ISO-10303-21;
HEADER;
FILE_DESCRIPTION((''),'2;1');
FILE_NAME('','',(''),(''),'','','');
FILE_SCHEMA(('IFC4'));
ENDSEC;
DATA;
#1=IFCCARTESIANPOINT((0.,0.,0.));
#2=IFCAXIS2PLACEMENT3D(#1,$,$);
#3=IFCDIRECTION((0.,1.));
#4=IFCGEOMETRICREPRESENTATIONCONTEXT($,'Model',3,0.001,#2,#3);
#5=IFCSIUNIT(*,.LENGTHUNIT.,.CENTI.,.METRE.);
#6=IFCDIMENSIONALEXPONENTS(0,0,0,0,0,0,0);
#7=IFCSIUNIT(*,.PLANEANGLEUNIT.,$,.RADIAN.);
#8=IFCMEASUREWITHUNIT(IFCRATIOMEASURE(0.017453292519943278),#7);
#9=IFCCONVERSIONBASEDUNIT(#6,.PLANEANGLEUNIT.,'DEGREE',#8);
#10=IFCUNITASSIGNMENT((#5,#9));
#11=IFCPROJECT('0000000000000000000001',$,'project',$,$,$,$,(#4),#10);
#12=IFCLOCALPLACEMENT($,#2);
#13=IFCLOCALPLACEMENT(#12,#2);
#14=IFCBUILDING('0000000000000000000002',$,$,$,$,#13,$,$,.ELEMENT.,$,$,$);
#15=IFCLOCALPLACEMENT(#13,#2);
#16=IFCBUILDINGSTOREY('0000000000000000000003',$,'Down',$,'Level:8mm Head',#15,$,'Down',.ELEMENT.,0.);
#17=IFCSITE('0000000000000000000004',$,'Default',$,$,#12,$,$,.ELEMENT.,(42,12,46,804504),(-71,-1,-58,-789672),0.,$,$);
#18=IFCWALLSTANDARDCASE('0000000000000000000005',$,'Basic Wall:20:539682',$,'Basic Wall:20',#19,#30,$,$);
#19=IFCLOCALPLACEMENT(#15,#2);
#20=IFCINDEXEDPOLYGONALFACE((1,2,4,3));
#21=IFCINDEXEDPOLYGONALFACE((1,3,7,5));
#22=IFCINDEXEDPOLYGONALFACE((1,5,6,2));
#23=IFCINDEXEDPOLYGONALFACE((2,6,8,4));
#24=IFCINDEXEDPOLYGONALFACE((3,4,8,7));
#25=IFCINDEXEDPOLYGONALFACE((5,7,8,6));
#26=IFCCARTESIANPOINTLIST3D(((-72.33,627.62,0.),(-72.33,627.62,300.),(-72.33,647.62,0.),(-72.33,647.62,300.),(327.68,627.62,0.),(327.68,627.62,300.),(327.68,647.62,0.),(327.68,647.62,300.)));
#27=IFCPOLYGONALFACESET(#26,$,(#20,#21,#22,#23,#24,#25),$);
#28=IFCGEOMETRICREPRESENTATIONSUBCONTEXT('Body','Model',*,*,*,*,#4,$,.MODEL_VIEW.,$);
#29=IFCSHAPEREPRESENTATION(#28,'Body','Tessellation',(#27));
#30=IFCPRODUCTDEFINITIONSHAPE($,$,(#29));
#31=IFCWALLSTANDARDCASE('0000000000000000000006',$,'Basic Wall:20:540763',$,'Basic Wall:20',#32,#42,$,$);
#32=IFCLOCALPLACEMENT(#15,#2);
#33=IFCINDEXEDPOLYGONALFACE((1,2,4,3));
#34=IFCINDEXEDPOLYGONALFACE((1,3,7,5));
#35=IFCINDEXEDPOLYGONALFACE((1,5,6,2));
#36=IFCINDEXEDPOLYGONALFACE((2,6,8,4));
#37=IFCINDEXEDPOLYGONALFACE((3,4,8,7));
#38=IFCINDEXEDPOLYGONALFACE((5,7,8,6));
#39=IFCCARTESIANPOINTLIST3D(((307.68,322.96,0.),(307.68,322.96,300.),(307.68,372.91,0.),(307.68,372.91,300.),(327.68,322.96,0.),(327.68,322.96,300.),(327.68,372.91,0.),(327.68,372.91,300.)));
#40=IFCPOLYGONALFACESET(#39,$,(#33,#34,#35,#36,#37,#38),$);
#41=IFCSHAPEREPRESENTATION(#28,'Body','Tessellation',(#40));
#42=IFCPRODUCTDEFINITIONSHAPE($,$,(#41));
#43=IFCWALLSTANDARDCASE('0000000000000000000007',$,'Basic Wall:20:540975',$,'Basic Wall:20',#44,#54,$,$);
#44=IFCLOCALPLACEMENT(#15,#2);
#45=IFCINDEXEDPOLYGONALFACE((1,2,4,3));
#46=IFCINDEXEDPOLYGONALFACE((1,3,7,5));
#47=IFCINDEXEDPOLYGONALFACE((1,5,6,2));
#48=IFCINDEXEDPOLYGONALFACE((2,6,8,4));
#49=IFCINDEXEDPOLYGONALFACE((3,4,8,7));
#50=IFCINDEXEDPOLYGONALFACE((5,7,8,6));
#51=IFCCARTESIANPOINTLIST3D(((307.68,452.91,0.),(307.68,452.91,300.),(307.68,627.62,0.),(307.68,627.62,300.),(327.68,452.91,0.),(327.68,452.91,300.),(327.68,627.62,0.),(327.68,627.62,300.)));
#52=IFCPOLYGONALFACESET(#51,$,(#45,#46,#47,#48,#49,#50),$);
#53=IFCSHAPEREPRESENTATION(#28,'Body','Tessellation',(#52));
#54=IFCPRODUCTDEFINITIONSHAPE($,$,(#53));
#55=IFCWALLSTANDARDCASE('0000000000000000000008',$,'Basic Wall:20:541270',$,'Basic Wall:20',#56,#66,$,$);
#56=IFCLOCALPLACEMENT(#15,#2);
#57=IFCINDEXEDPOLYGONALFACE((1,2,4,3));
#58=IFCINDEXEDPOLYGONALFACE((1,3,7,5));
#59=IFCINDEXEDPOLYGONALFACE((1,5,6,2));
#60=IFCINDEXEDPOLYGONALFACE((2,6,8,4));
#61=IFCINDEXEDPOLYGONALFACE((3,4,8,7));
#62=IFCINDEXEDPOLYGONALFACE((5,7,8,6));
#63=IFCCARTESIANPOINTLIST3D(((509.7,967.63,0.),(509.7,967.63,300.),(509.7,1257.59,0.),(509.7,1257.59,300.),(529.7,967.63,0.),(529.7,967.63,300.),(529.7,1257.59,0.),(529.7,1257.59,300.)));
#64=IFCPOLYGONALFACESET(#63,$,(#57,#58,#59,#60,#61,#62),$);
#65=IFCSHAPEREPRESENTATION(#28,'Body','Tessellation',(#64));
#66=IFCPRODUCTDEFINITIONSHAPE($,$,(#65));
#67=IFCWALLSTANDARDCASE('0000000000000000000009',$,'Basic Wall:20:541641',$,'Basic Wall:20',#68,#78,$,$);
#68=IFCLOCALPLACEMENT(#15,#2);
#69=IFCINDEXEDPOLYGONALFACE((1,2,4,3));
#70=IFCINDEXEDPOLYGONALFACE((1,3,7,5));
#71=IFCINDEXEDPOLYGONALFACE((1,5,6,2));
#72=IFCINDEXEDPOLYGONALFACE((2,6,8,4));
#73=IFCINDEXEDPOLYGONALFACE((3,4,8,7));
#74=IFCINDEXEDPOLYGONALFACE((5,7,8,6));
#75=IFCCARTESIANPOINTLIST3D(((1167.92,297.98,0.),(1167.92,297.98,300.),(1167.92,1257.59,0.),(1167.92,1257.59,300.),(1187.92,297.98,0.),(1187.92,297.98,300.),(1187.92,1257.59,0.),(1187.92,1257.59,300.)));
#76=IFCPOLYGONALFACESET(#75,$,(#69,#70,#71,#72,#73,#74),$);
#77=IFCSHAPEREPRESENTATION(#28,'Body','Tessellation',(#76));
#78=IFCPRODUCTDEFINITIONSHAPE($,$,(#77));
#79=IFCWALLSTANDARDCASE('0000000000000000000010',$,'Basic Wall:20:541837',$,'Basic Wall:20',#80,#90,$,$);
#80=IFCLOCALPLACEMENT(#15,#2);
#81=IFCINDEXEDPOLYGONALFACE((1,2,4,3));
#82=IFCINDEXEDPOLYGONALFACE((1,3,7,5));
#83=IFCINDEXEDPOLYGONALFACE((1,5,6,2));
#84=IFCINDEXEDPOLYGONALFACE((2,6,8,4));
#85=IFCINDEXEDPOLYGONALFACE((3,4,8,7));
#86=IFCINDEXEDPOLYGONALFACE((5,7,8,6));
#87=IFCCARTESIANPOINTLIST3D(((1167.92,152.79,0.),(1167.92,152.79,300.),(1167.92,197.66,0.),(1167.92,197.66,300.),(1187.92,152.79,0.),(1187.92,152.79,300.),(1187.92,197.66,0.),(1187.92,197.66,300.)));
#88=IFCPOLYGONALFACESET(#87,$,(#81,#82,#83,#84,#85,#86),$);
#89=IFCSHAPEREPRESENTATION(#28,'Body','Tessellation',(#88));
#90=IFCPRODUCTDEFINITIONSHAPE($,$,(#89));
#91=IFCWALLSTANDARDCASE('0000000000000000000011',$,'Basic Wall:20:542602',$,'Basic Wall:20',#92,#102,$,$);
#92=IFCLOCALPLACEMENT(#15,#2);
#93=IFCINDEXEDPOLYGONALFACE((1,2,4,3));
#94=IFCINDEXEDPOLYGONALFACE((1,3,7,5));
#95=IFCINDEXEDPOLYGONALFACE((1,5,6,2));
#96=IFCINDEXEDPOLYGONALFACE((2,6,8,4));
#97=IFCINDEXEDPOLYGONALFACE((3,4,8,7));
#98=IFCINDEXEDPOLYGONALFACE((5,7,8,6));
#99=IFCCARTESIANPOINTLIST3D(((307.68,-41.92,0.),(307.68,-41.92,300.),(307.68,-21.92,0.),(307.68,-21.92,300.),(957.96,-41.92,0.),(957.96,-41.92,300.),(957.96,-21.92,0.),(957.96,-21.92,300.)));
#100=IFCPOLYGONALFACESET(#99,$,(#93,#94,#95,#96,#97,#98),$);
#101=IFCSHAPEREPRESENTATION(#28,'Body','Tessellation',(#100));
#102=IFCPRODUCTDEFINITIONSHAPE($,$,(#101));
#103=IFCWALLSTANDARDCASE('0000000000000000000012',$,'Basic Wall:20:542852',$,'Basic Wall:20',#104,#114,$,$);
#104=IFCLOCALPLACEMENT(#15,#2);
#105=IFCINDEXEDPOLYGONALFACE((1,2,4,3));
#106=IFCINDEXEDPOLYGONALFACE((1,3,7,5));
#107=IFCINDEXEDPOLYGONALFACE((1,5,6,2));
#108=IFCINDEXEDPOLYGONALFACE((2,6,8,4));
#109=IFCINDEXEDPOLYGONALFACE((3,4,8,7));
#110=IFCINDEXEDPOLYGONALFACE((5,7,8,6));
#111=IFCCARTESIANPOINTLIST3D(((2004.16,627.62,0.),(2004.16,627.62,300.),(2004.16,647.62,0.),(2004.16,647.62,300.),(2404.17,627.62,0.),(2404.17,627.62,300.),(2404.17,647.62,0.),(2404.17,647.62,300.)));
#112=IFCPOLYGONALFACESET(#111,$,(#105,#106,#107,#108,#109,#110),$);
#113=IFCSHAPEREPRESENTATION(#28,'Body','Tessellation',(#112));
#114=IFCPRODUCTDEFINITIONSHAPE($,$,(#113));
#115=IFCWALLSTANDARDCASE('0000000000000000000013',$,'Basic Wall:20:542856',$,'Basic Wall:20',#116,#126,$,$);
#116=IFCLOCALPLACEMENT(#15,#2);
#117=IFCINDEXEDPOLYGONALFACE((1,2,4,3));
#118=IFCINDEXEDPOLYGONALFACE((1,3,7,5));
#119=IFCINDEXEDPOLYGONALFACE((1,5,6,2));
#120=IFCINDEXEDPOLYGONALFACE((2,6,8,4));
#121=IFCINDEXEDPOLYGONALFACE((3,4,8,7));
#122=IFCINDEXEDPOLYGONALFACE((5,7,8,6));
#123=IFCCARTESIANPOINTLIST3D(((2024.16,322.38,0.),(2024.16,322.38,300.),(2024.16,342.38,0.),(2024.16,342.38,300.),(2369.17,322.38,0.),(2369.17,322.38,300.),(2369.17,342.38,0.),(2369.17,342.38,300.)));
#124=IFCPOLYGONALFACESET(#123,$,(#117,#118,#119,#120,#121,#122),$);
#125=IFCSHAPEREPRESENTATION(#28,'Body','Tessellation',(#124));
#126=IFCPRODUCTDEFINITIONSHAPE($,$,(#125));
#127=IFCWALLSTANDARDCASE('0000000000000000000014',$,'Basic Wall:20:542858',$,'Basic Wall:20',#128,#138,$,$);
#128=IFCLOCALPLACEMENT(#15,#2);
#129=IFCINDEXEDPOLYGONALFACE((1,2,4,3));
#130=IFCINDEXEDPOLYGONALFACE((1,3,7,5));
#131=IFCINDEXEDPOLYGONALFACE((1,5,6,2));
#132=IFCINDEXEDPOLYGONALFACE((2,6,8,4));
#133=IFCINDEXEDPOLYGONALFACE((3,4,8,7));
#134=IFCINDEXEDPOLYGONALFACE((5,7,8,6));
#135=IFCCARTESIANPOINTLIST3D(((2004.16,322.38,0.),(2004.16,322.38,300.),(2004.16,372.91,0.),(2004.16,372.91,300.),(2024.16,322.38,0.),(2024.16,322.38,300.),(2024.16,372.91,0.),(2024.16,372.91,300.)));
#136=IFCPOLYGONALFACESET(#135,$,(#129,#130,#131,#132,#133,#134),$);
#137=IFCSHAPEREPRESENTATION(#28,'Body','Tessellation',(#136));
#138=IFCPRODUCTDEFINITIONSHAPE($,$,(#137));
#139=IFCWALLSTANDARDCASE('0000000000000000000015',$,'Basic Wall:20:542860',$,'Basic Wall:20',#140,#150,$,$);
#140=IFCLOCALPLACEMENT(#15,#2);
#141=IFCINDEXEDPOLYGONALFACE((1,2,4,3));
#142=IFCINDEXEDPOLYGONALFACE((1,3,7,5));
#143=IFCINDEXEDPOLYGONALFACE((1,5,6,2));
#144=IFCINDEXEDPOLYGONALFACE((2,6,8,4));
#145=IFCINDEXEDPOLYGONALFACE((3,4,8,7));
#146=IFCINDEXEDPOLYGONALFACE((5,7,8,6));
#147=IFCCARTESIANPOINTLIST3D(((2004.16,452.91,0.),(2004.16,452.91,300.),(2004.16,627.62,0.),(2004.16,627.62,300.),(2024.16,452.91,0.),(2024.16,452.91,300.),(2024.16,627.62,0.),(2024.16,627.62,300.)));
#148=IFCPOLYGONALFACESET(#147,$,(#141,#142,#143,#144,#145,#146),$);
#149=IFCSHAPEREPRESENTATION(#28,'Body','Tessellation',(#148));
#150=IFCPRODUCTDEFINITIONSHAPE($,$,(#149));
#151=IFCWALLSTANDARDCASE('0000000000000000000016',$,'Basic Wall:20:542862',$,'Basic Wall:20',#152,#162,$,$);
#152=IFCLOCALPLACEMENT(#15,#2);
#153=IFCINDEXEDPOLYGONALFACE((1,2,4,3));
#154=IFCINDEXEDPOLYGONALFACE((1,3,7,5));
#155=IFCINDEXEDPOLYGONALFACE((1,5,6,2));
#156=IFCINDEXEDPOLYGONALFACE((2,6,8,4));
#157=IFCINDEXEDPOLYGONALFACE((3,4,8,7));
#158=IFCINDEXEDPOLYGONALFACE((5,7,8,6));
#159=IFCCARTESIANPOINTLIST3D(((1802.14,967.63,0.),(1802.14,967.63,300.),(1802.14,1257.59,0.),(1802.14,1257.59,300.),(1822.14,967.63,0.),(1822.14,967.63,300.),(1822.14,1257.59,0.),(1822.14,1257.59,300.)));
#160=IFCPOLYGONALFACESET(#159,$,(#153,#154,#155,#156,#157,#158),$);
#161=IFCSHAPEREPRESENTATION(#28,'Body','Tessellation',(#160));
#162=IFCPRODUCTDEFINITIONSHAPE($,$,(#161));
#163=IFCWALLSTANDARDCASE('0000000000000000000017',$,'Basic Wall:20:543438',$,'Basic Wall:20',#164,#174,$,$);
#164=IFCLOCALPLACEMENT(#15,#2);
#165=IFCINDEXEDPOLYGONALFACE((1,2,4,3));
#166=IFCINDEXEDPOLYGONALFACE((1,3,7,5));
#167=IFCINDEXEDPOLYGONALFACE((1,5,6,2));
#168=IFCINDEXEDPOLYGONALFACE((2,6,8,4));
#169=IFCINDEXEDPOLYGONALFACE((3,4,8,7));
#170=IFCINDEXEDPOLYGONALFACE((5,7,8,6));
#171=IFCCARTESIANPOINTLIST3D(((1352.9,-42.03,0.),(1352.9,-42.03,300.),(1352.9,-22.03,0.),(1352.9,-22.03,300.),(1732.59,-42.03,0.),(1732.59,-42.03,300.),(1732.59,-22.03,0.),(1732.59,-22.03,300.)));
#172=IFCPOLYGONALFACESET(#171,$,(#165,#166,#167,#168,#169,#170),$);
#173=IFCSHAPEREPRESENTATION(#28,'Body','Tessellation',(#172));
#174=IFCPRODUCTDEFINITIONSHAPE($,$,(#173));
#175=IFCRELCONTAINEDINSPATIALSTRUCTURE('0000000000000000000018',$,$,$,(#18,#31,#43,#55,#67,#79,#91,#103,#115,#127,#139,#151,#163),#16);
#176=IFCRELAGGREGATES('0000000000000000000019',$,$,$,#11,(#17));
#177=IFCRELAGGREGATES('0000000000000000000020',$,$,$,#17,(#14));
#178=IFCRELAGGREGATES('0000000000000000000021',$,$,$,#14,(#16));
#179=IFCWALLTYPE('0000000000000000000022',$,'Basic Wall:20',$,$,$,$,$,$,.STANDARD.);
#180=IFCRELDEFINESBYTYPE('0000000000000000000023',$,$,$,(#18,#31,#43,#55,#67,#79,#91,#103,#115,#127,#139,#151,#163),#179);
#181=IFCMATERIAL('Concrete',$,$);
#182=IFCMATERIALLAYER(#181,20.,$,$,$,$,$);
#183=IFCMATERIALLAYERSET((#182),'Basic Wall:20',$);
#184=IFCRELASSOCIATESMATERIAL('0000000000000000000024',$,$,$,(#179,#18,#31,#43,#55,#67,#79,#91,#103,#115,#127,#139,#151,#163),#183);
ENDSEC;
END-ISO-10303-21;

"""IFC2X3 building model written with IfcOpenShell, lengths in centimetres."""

from ifc_helpers import new_model, entity, si_unit, converted_unit, direction, frame, frame_2d, origin, place, context, subcontext, project, spatial, rectangle, extrude, material, layer, layer_set, layer_usage, type_object, element, save


model = new_model("IFC2X3")

# Units and contexts
model_context = context("Model", 3, precision=0.001, world=origin(), true_north=direction((0.0, 1.0)))
body_context = subcontext(model_context, "Body", "Model", "MODEL_VIEW")
ifc_project = project(units=[si_unit("LENGTHUNIT", "METRE", prefix="CENTI"), converted_unit("PLANEANGLEUNIT", "DEGREE", entity("IfcRatioMeasure", 0.017453292519943278), si_unit("PLANEANGLEUNIT", "RADIAN"), dimensions=[0, 0, 0, 0, 0, 0, 0])], contexts=[model_context])

# Site, building, storey
site_placement = place(None, origin())
site = spatial("IfcSite", under=ifc_project, at=site_placement, Name="Default", CompositionType="ELEMENT", RefLatitude=(42, 12, 46, 804504), RefLongitude=(-71, -1, -58, -789672), RefElevation=0.0)
building_placement = place(site_placement, origin())
building = spatial("IfcBuilding", under=site, at=building_placement, CompositionType="ELEMENT")
storey_placement = place(building_placement, origin())
storey = spatial("IfcBuildingStorey", under=building, at=storey_placement, Name="Down", ObjectType="Level:8mm Head", LongName="Down", CompositionType="ELEMENT", Elevation=0.0)

# Shared definitions
ifc_material = material(Name="Concrete")

# Walls
ifc_layer_1 = layer(ifc_material, 20.0)
ifc_layer_set_1 = layer_set([ifc_layer_1], Name="Basic Wall:20")
ifc_layer_usage_1 = layer_usage(ifc_layer_set_1, "AXIS2", "POSITIVE", -10.0)
wall_type_1 = type_object("IfcWallType", Name="Basic Wall:20", PredefinedType="STANDARD", material=ifc_layer_set_1)
wall_1_placement = place(storey_placement, frame((327.68, 637.62, 0.0), z_axis=(0.0, 0.0, 1.0), x_axis=(-1.0, 0.0, 0.0)))
element("IfcWallStandardCase", 1, at=wall_1_placement, inside=storey, type_object=wall_type_1, material=ifc_layer_usage_1, Name="Basic Wall:20:539682", ObjectType="Basic Wall:20", context=body_context, shape_type="SweptSolid", body=[
    extrude(rectangle(XDim=400.01, YDim=20.0, at=frame_2d((200.01, 0.0), x_axis=(-1.0, 0.0))), origin(), (0.0, 0.0, 1.0), 300.0),
])
ifc_layer_usage_2 = layer_usage(ifc_layer_set_1, "AXIS2", "POSITIVE", -10.0)
wall_2_placement = place(storey_placement, frame((317.68, 322.96, 0.0), z_axis=(0.0, 0.0, 1.0), x_axis=(0.0, 1.0, 0.0)))
element("IfcWallStandardCase", 2, at=wall_2_placement, inside=storey, type_object=wall_type_1, material=ifc_layer_usage_2, Name="Basic Wall:20:540763", ObjectType="Basic Wall:20", context=body_context, shape_type="SweptSolid", body=[
    extrude(rectangle(XDim=49.95, YDim=20.0, at=frame_2d((24.97, 0.0), x_axis=(-1.0, 0.0))), origin(), (0.0, 0.0, 1.0), 300.0),
])
ifc_layer_usage_3 = layer_usage(ifc_layer_set_1, "AXIS2", "POSITIVE", -10.0)
wall_3_placement = place(storey_placement, frame((317.68, 452.91, 0.0), z_axis=(0.0, 0.0, 1.0), x_axis=(0.0, 1.0, 0.0)))
element("IfcWallStandardCase", 3, at=wall_3_placement, inside=storey, type_object=wall_type_1, material=ifc_layer_usage_3, Name="Basic Wall:20:540975", ObjectType="Basic Wall:20", context=body_context, shape_type="SweptSolid", body=[
    extrude(rectangle(XDim=174.72, YDim=20.0, at=frame_2d((87.36, 0.0), x_axis=(-1.0, 0.0))), origin(), (0.0, 0.0, 1.0), 300.0),
])
ifc_layer_usage_4 = layer_usage(ifc_layer_set_1, "AXIS2", "NEGATIVE", 10.0)
wall_4_placement = place(storey_placement, frame((519.7, 967.63, 0.0), z_axis=(0.0, 0.0, 1.0), x_axis=(0.0, 1.0, 0.0)))
element("IfcWallStandardCase", 4, at=wall_4_placement, inside=storey, type_object=wall_type_1, material=ifc_layer_usage_4, Name="Basic Wall:20:541270", ObjectType="Basic Wall:20", context=body_context, shape_type="SweptSolid", body=[
    extrude(rectangle(XDim=289.96, YDim=20.0, at=frame_2d((144.98, 0.0), x_axis=(-1.0, 0.0))), origin(), (0.0, 0.0, 1.0), 300.0),
])
ifc_layer_usage_5 = layer_usage(ifc_layer_set_1, "AXIS2", "POSITIVE", -10.0)
wall_5_placement = place(storey_placement, frame((1177.92, 1257.59, 0.0), z_axis=(0.0, 0.0, 1.0), x_axis=(0.0, -1.0, 0.0)))
element("IfcWallStandardCase", 5, at=wall_5_placement, inside=storey, type_object=wall_type_1, material=ifc_layer_usage_5, Name="Basic Wall:20:541641", ObjectType="Basic Wall:20", context=body_context, shape_type="SweptSolid", body=[
    extrude(rectangle(XDim=959.61, YDim=20.0, at=frame_2d((479.8, 0.0), x_axis=(-1.0, 0.0))), origin(), (0.0, 0.0, 1.0), 300.0),
])
ifc_layer_usage_6 = layer_usage(ifc_layer_set_1, "AXIS2", "POSITIVE", -10.0)
wall_6_placement = place(storey_placement, frame((1177.92, 197.66, 0.0), z_axis=(0.0, 0.0, 1.0), x_axis=(0.0, -1.0, 0.0)))
element("IfcWallStandardCase", 6, at=wall_6_placement, inside=storey, type_object=wall_type_1, material=ifc_layer_usage_6, Name="Basic Wall:20:541837", ObjectType="Basic Wall:20", context=body_context, shape_type="SweptSolid", body=[
    extrude(rectangle(XDim=44.87, YDim=20.0, at=frame_2d((22.43, 0.0), x_axis=(-1.0, 0.0))), origin(), (0.0, 0.0, 1.0), 300.0),
])
ifc_layer_usage_7 = layer_usage(ifc_layer_set_1, "AXIS2", "NEGATIVE", 10.0)
wall_7_placement = place(storey_placement, frame((957.96, -31.92, 0.0), z_axis=(0.0, 0.0, 1.0), x_axis=(-1.0, 0.0, 0.0)))
element("IfcWallStandardCase", 7, at=wall_7_placement, inside=storey, type_object=wall_type_1, material=ifc_layer_usage_7, Name="Basic Wall:20:542602", ObjectType="Basic Wall:20", context=body_context, shape_type="SweptSolid", body=[
    extrude(rectangle(XDim=650.28, YDim=20.0, at=frame_2d((325.14, 0.0), x_axis=(-1.0, 0.0))), origin(), (0.0, 0.0, 1.0), 300.0),
])
ifc_layer_usage_8 = layer_usage(ifc_layer_set_1, "AXIS2", "NEGATIVE", 10.0)
wall_8_placement = place(storey_placement, frame((2004.16, 637.62, 0.0)))
element("IfcWallStandardCase", 8, at=wall_8_placement, inside=storey, type_object=wall_type_1, material=ifc_layer_usage_8, Name="Basic Wall:20:542852", ObjectType="Basic Wall:20", context=body_context, shape_type="SweptSolid", body=[
    extrude(rectangle(XDim=400.01, YDim=20.0, at=frame_2d((200.01, 0.0), x_axis=(-1.0, 0.0))), origin(), (0.0, 0.0, 1.0), 300.0),
])
ifc_layer_usage_9 = layer_usage(ifc_layer_set_1, "AXIS2", "NEGATIVE", 10.0)
wall_9_placement = place(storey_placement, frame((2369.17, 332.38, 0.0), z_axis=(0.0, 0.0, 1.0), x_axis=(-1.0, 0.0, 0.0)))
element("IfcWallStandardCase", 9, at=wall_9_placement, inside=storey, type_object=wall_type_1, material=ifc_layer_usage_9, Name="Basic Wall:20:542856", ObjectType="Basic Wall:20", context=body_context, shape_type="SweptSolid", body=[
    extrude(rectangle(XDim=345.01, YDim=20.0, at=frame_2d((172.51, 0.0), x_axis=(-1.0, 0.0))), origin(), (0.0, 0.0, 1.0), 300.0),
])
ifc_layer_usage_10 = layer_usage(ifc_layer_set_1, "AXIS2", "NEGATIVE", 10.0)
wall_10_placement = place(storey_placement, frame((2014.16, 322.38, 0.0), z_axis=(0.0, 0.0, 1.0), x_axis=(0.0, 1.0, 0.0)))
element("IfcWallStandardCase", 10, at=wall_10_placement, inside=storey, type_object=wall_type_1, material=ifc_layer_usage_10, Name="Basic Wall:20:542858", ObjectType="Basic Wall:20", context=body_context, shape_type="SweptSolid", body=[
    extrude(rectangle(XDim=50.52, YDim=20.0, at=frame_2d((25.26, 0.0), x_axis=(-1.0, 0.0))), origin(), (0.0, 0.0, 1.0), 300.0),
])
ifc_layer_usage_11 = layer_usage(ifc_layer_set_1, "AXIS2", "NEGATIVE", 10.0)
wall_11_placement = place(storey_placement, frame((2014.16, 452.91, 0.0), z_axis=(0.0, 0.0, 1.0), x_axis=(0.0, 1.0, 0.0)))
element("IfcWallStandardCase", 11, at=wall_11_placement, inside=storey, type_object=wall_type_1, material=ifc_layer_usage_11, Name="Basic Wall:20:542860", ObjectType="Basic Wall:20", context=body_context, shape_type="SweptSolid", body=[
    extrude(rectangle(XDim=174.72, YDim=20.0, at=frame_2d((87.36, 0.0), x_axis=(-1.0, 0.0))), origin(), (0.0, 0.0, 1.0), 300.0),
])
ifc_layer_usage_12 = layer_usage(ifc_layer_set_1, "AXIS2", "POSITIVE", -10.0)
wall_12_placement = place(storey_placement, frame((1812.14, 967.63, 0.0), z_axis=(0.0, 0.0, 1.0), x_axis=(0.0, 1.0, 0.0)))
element("IfcWallStandardCase", 12, at=wall_12_placement, inside=storey, type_object=wall_type_1, material=ifc_layer_usage_12, Name="Basic Wall:20:542862", ObjectType="Basic Wall:20", context=body_context, shape_type="SweptSolid", body=[
    extrude(rectangle(XDim=289.96, YDim=20.0, at=frame_2d((144.98, 0.0), x_axis=(-1.0, 0.0))), origin(), (0.0, 0.0, 1.0), 300.0),
])
ifc_layer_usage_13 = layer_usage(ifc_layer_set_1, "AXIS2", "NEGATIVE", 10.0)
wall_13_placement = place(storey_placement, frame((1352.9, -32.03, 0.0)))
element("IfcWallStandardCase", 13, at=wall_13_placement, inside=storey, type_object=wall_type_1, material=ifc_layer_usage_13, Name="Basic Wall:20:543438", ObjectType="Basic Wall:20", context=body_context, shape_type="SweptSolid", body=[
    extrude(rectangle(XDim=379.69, YDim=20.0, at=frame_2d((189.85, 0.0), x_axis=(-1.0, 0.0))), origin(), (0.0, 0.0, 1.0), 300.0),
])

save(model, "model.ifc")
